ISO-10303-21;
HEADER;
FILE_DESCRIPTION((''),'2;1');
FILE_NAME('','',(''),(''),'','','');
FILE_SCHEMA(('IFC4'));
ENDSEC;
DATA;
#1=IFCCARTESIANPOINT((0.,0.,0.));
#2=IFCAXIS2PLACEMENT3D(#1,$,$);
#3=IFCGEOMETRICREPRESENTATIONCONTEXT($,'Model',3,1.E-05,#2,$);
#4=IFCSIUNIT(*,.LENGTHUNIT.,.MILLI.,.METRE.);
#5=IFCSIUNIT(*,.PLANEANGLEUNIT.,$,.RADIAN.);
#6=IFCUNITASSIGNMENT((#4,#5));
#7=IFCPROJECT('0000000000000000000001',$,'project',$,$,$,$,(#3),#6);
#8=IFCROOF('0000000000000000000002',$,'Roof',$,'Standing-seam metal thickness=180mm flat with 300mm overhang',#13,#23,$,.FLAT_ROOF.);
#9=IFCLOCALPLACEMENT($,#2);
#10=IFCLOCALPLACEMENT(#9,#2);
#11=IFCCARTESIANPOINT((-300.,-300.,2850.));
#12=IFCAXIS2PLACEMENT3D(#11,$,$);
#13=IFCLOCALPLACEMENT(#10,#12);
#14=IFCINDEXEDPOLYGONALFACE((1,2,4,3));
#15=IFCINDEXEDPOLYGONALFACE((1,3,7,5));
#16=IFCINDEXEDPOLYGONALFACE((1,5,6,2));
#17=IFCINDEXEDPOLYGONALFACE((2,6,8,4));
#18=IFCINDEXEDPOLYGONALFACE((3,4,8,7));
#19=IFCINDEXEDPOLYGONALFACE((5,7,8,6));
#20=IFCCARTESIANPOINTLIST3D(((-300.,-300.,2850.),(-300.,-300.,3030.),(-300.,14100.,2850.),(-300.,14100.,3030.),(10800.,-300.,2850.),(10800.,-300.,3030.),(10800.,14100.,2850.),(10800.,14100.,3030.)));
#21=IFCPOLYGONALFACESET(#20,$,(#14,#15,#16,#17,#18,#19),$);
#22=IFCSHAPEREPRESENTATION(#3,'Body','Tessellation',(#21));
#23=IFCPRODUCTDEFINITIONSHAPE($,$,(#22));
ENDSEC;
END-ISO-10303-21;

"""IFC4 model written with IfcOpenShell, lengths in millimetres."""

from ifc_helpers import new_model, si_unit, frame, frame_2d, origin, place, context, project, rectangle, extrude, element, save


model = new_model("IFC4")

# Units and contexts
model_context = context("Model", 3, precision=1e-05, world=origin())
ifc_project = project(units=[si_unit("LENGTHUNIT", "METRE", prefix="MILLI"), si_unit("PLANEANGLEUNIT", "RADIAN")], contexts=[model_context])

# Roof
placement_1 = place(None, origin())
placement_2 = place(placement_1, origin())
roof_placement = place(placement_2, frame((-300.0, -300.0, 2850.0)))
element("IfcRoof", 1, at=roof_placement, Name="Roof", ObjectType="Standing-seam metal thickness=180mm flat with 300mm overhang", PredefinedType="FLAT_ROOF", context=model_context, shape_type="SweptSolid", body=[
    extrude(rectangle(XDim=11100.0, YDim=14400.0, at=frame_2d((5550.0, 7200.0))), frame((-300.0, -300.0, 2850.0)), (0.0, 0.0, 1.0), 180.0),
])

save(model, "model.ifc")
